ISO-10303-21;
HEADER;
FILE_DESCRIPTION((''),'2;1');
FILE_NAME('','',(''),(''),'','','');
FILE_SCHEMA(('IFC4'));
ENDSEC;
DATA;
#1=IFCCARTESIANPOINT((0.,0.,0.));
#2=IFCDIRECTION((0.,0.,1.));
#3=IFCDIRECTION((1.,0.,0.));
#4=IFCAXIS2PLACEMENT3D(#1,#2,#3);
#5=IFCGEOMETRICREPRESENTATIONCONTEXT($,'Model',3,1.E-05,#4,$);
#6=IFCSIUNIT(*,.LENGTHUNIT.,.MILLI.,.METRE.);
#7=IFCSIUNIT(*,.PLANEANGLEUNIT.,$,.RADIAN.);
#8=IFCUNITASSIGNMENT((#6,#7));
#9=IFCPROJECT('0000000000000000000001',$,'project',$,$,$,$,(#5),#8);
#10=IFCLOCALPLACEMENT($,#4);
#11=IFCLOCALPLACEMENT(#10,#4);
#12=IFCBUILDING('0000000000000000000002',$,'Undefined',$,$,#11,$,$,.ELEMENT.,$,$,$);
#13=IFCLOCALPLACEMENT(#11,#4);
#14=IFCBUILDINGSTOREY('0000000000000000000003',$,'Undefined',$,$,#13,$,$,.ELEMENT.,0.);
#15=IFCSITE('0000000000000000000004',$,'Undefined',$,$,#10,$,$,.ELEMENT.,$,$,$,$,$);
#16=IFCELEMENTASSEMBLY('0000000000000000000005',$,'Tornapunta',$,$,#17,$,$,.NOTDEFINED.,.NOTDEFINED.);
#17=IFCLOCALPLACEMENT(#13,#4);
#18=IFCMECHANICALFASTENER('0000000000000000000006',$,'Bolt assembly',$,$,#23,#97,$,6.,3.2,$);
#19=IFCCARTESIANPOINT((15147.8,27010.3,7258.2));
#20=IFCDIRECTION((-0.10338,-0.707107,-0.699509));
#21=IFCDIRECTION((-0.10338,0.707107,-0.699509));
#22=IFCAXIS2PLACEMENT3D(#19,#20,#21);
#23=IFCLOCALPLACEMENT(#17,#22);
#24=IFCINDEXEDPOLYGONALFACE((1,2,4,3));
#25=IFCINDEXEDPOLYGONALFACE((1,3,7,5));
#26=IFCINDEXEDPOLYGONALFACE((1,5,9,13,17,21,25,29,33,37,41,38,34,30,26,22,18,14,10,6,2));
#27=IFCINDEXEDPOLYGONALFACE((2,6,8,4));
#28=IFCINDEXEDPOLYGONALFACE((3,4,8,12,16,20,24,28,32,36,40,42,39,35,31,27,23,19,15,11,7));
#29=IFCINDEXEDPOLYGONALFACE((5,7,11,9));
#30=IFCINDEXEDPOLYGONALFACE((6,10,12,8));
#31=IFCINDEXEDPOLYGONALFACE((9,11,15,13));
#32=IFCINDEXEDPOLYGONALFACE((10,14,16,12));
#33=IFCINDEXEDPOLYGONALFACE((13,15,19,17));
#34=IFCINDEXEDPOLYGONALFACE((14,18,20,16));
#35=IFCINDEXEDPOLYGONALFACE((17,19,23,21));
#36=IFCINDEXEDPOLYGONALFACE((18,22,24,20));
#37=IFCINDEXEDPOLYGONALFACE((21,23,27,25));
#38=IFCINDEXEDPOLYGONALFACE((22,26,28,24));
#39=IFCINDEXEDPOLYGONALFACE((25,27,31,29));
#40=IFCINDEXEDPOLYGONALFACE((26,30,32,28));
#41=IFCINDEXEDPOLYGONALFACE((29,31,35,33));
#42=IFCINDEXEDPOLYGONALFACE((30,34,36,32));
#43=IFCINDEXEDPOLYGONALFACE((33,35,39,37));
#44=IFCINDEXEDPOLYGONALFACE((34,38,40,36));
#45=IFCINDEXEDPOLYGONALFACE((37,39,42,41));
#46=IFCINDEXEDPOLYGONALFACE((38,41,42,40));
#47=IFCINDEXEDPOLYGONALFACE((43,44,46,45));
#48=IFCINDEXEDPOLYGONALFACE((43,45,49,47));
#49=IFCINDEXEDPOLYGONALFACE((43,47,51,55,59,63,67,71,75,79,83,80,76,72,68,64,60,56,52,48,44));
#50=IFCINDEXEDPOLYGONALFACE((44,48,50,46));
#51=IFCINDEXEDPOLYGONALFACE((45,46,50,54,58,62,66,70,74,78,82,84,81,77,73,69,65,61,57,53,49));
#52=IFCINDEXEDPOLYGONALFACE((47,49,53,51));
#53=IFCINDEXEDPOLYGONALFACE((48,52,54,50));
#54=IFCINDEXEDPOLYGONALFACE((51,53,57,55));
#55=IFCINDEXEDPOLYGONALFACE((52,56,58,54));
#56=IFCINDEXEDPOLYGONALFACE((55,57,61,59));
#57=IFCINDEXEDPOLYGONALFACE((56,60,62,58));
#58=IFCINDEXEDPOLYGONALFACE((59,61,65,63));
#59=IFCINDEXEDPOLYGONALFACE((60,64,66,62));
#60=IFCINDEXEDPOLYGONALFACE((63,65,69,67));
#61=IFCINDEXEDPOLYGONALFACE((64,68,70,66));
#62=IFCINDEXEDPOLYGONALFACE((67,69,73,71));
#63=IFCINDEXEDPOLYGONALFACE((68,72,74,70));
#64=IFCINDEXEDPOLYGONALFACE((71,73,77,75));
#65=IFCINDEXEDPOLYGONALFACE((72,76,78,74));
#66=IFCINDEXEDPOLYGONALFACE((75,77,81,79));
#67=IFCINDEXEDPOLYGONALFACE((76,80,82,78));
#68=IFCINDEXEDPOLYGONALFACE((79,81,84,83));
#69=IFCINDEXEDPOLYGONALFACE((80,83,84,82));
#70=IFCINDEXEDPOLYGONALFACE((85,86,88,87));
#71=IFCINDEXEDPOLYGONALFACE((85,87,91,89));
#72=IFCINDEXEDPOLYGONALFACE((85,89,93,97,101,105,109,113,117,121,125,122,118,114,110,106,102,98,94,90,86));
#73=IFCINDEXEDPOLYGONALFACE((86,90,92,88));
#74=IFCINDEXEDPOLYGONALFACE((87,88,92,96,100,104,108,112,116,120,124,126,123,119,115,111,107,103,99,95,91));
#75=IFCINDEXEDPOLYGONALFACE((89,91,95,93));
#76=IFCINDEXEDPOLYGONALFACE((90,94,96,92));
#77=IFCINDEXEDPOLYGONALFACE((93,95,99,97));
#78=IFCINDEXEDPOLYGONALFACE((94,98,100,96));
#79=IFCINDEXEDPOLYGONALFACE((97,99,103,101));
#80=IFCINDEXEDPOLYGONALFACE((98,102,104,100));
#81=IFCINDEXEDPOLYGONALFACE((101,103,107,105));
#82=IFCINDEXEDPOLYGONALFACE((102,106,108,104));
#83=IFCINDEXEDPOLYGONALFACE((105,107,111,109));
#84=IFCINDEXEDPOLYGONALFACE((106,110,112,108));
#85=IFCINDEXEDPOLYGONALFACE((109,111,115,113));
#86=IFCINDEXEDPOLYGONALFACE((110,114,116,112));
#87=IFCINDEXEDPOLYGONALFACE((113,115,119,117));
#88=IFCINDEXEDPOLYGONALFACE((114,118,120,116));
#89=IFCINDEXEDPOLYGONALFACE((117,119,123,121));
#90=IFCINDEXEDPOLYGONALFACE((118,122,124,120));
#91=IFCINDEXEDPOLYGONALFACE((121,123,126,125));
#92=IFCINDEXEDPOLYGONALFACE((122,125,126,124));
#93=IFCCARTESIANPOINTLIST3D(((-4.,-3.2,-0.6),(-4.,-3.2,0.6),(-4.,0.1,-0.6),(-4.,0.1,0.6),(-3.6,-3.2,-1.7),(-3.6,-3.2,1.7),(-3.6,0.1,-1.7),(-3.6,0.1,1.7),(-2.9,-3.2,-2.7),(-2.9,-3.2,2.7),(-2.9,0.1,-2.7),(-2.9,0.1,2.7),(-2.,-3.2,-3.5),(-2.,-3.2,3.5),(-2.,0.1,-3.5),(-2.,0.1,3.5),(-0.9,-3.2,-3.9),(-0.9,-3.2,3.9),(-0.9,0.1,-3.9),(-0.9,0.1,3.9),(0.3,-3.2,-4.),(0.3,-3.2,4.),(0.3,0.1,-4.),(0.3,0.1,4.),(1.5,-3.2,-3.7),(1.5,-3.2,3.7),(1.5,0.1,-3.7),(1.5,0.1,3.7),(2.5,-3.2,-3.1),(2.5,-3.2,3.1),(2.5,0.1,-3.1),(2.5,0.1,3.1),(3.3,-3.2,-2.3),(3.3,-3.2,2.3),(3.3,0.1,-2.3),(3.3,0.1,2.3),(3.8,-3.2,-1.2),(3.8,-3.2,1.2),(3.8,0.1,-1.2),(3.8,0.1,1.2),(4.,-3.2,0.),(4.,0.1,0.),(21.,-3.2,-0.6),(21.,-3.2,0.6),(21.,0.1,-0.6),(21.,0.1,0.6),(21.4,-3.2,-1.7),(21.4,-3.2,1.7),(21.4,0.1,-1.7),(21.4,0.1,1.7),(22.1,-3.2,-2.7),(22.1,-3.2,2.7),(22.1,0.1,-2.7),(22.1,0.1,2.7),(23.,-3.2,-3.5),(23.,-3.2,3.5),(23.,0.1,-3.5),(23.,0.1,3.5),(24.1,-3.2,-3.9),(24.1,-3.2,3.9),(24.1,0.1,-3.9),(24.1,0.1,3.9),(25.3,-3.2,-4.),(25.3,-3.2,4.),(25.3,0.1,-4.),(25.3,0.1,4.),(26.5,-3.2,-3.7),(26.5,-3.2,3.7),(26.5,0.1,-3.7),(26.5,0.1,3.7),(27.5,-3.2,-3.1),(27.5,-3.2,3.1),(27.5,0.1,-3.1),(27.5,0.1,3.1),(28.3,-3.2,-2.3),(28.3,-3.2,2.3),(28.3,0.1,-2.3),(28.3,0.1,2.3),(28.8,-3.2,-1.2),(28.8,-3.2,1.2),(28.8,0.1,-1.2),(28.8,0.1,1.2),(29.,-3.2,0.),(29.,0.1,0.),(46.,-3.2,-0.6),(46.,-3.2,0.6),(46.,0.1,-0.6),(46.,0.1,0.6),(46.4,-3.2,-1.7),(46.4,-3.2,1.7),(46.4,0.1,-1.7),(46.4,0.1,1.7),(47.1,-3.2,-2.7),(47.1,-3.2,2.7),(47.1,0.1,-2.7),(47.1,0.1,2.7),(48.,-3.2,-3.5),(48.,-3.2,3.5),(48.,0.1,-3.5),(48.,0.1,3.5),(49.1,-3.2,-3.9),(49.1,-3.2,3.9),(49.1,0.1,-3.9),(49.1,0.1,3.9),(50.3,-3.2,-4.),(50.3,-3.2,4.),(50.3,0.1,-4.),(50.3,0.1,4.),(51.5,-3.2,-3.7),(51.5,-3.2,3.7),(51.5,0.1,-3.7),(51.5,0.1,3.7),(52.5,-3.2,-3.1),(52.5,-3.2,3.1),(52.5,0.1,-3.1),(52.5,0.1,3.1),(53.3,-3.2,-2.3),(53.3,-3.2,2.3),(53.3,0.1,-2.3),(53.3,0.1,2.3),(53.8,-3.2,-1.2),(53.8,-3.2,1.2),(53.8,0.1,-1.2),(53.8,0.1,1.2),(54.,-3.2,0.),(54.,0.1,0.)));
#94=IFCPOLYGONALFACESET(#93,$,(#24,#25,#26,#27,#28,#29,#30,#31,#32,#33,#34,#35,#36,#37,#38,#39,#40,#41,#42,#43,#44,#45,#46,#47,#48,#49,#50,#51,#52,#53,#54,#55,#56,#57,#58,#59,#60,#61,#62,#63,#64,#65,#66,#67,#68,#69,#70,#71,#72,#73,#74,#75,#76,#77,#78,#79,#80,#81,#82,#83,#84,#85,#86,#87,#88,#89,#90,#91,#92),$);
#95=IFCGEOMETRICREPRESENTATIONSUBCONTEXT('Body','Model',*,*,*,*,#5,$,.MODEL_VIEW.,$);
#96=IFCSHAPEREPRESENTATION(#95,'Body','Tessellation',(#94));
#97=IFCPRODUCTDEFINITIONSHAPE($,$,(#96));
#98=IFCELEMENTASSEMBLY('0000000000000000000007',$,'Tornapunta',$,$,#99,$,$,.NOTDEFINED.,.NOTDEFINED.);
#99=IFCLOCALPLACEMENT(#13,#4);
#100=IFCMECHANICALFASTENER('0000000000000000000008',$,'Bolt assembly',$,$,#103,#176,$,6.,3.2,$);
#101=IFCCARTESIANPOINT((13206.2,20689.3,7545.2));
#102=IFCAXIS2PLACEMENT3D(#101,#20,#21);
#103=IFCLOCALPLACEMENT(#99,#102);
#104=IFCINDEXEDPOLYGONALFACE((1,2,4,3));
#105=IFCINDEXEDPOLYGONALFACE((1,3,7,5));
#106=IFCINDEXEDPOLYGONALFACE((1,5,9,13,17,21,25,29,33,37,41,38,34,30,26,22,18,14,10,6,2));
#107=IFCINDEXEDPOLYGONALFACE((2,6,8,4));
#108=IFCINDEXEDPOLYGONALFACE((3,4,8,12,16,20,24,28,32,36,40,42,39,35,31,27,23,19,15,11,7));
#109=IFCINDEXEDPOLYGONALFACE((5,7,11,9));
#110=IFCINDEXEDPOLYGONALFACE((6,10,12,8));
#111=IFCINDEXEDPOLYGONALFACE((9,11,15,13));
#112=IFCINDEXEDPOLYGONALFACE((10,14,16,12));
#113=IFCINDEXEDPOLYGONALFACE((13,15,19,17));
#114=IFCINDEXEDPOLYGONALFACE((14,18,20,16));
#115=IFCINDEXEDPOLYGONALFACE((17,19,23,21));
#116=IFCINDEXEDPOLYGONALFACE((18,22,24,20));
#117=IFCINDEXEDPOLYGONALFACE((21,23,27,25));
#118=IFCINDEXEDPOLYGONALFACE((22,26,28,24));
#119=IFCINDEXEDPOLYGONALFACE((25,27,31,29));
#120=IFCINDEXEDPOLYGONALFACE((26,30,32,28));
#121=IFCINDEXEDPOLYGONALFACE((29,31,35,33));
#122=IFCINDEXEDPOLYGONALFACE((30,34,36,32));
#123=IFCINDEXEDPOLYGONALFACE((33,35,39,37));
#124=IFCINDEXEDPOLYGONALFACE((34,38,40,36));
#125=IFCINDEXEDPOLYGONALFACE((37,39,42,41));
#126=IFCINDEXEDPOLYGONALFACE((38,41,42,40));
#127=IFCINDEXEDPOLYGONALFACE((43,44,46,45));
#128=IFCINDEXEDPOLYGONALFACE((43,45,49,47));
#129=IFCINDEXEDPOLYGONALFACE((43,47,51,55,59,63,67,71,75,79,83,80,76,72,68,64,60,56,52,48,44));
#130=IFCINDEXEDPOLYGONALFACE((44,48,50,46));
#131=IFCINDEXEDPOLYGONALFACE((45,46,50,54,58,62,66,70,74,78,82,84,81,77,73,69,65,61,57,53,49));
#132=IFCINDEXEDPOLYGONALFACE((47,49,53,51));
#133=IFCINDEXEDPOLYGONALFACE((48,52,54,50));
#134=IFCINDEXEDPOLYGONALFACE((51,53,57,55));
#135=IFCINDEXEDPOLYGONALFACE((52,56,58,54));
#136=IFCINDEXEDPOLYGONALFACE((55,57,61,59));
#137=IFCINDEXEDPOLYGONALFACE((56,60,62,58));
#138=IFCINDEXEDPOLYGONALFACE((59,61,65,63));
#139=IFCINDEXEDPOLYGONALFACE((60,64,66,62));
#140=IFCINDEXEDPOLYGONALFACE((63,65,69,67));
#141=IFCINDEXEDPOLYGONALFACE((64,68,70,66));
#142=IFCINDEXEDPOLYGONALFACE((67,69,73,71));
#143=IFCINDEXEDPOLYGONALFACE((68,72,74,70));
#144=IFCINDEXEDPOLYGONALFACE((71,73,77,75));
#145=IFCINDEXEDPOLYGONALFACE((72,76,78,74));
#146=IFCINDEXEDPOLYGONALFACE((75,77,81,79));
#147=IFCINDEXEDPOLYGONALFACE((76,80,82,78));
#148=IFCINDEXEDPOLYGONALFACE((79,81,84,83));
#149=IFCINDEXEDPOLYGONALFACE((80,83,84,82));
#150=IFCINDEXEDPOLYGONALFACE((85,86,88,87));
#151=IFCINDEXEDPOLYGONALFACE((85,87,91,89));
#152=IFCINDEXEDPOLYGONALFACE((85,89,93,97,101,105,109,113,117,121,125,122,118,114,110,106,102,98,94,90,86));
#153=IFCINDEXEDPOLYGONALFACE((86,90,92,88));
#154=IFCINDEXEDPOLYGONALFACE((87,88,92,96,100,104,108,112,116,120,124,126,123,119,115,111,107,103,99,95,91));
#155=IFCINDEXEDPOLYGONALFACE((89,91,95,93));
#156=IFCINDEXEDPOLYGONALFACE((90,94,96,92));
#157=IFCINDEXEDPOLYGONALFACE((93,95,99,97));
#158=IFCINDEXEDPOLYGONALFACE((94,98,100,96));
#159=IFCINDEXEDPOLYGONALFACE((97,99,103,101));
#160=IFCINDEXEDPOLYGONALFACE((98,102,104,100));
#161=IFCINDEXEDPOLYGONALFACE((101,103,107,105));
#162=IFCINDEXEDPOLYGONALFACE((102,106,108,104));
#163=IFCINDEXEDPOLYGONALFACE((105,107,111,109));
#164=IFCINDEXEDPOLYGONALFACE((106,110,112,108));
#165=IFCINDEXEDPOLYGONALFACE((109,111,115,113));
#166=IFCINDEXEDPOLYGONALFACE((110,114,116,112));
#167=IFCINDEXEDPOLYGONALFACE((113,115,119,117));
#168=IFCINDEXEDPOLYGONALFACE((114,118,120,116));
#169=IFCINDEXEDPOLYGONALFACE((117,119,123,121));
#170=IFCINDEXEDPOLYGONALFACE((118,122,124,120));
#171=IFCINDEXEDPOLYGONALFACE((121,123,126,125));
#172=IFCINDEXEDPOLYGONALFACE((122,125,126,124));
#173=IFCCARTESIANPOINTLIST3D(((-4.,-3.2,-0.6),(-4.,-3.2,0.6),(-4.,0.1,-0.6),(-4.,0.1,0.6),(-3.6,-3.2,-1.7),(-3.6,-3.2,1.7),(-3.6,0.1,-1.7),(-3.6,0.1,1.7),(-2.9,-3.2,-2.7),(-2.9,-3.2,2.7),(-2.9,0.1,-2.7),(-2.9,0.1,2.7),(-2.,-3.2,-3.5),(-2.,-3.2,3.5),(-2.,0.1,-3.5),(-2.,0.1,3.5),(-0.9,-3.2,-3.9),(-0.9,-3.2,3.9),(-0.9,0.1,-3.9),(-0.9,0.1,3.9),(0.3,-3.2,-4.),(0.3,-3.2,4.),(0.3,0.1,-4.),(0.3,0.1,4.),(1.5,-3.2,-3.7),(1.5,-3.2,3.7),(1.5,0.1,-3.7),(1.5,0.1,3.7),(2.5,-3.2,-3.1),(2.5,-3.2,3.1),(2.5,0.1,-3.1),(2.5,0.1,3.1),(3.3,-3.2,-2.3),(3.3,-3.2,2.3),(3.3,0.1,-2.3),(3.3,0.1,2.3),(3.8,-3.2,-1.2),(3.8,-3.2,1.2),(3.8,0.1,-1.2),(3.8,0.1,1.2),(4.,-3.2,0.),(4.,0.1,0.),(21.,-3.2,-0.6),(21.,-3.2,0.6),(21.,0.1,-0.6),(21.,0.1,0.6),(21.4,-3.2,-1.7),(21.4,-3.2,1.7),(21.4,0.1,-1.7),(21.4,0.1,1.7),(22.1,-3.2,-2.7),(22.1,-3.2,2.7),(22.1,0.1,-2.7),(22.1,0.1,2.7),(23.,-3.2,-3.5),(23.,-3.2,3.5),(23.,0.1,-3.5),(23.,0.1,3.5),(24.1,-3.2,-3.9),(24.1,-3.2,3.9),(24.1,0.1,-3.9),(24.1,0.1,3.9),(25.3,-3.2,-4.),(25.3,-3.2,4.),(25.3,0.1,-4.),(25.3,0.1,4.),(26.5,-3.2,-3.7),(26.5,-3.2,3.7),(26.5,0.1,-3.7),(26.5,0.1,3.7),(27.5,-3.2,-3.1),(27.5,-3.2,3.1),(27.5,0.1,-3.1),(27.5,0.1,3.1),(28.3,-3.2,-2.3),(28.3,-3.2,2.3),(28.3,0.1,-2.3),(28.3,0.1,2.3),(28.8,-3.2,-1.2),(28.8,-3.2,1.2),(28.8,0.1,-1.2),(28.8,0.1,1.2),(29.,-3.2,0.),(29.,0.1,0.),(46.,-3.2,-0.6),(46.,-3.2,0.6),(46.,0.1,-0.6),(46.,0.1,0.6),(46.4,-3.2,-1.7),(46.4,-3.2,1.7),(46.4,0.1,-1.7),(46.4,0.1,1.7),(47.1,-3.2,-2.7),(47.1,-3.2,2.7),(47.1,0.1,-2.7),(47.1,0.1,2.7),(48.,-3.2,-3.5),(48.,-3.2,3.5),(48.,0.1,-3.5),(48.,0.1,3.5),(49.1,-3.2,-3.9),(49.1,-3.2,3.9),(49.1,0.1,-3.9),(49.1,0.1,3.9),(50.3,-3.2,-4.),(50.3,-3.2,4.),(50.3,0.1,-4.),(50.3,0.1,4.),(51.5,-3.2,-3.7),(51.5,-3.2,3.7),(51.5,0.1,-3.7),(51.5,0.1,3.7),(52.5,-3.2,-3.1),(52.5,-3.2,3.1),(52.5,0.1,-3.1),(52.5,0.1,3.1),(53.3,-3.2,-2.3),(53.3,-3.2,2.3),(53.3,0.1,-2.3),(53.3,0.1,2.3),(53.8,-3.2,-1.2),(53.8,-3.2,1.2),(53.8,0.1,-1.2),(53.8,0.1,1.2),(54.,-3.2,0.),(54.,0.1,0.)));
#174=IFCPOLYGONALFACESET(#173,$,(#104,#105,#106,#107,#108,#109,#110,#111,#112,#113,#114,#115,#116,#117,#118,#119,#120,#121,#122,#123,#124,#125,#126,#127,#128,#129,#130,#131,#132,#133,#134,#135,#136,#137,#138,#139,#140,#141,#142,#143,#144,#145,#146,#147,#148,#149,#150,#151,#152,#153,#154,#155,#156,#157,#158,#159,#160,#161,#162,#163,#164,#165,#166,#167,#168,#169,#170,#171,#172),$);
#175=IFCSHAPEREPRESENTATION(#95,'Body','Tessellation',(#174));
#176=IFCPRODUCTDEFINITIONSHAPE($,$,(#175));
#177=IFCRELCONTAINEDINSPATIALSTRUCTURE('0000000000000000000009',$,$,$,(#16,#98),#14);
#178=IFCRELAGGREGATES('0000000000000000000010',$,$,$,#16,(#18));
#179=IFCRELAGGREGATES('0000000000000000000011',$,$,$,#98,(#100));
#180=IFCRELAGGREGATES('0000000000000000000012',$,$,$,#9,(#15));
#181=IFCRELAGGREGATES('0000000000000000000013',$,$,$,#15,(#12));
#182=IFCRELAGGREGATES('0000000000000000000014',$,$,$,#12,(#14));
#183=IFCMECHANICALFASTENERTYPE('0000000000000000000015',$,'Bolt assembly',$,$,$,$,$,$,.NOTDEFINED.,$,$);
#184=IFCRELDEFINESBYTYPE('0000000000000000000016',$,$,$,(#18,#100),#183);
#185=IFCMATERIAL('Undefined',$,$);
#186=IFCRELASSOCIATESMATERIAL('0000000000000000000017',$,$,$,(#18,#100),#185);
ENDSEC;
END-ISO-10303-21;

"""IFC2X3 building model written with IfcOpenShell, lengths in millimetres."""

from ifc_helpers import new_model, si_unit, frame, origin_with_axes, origin_2d_with_axis, place, context, subcontext, project, spatial, circle, extrude, source, transform, mapped, material, type_object, element, aggregate, save


model = new_model("IFC2X3")

# Units and contexts
model_context = context("Model", 3, precision=1e-05, world=origin_with_axes())
body_context = subcontext(model_context, "Body", "Model", "MODEL_VIEW")
ifc_project = project(units=[si_unit("LENGTHUNIT", "METRE", prefix="MILLI"), si_unit("PLANEANGLEUNIT", "RADIAN")], contexts=[model_context])

# Site, building, storey
site_placement = place(None, origin_with_axes())
site = spatial("IfcSite", under=ifc_project, at=site_placement, Name="Undefined", CompositionType="ELEMENT")
building_placement = place(site_placement, origin_with_axes())
building = spatial("IfcBuilding", under=site, at=building_placement, Name="Undefined", CompositionType="ELEMENT")
storey_placement = place(building_placement, origin_with_axes())
storey = spatial("IfcBuildingStorey", under=building, at=storey_placement, Name="Undefined", CompositionType="ELEMENT", Elevation=0.0)

# Shared definitions
ifc_material_1 = material(Name="Undefined")
mechanical_fastener_type = type_object("IfcMechanicalFastenerType", Name="Bolt assembly")

# Element assemblies, mechanical fasteners
shared_shape_1 = source(origin_with_axes(), body_context, "Body", "SweptSolid", [
    extrude(circle(Radius=4.0, at=origin_2d_with_axis()), frame((0.0, -3.2, 0.0), z_axis=(0.0, 1.0, 0.0), x_axis=(1.0, 0.0, 0.0)), (0.0, 0.0, 1.0), 3.3),
])
assembly_1_placement = place(storey_placement, origin_with_axes())
assembly_1 = element("IfcElementAssembly", 1, at=assembly_1_placement, inside=storey, Name="Tornapunta", AssemblyPlace="NOTDEFINED", PredefinedType="NOTDEFINED")
mechanical_fastener_1_placement = place(assembly_1_placement, frame((15147.8, 27010.3, 7258.2), z_axis=(-0.10338, -0.707107, -0.699509), x_axis=(-0.10338, 0.707107, -0.699509)))
mechanical_fastener_1 = element("IfcMechanicalFastener", 2, at=mechanical_fastener_1_placement, type_object=mechanical_fastener_type, material=ifc_material_1, Name="Bolt assembly", NominalDiameter=6.0, NominalLength=3.2, context=body_context, shape_type="MappedRepresentation", body=[
    mapped(shared_shape_1, transform((0.0, 0.0, 0.0))),
    mapped(shared_shape_1, transform((25.0, 0.0, 0.0))),
    mapped(shared_shape_1, transform((50.0, 0.0, 0.0))),
])
aggregate(assembly_1, [mechanical_fastener_1])
assembly_2_placement = place(storey_placement, origin_with_axes())
assembly_2 = element("IfcElementAssembly", 3, at=assembly_2_placement, inside=storey, Name="Tornapunta", AssemblyPlace="NOTDEFINED", PredefinedType="NOTDEFINED")
mechanical_fastener_2_placement = place(assembly_2_placement, frame((13206.2, 20689.3, 7545.2), z_axis=(-0.10338, -0.707107, -0.699509), x_axis=(-0.10338, 0.707107, -0.699509)))
mechanical_fastener_2 = element("IfcMechanicalFastener", 4, at=mechanical_fastener_2_placement, type_object=mechanical_fastener_type, material=ifc_material_1, Name="Bolt assembly", NominalDiameter=6.0, NominalLength=3.2, context=body_context, shape_type="MappedRepresentation", body=[
    mapped(shared_shape_1, transform((0.0, 0.0, 0.0))),
    mapped(shared_shape_1, transform((25.0, 0.0, 0.0))),
    mapped(shared_shape_1, transform((50.0, 0.0, 0.0))),
])
aggregate(assembly_2, [mechanical_fastener_2])

save(model, "model.ifc")
